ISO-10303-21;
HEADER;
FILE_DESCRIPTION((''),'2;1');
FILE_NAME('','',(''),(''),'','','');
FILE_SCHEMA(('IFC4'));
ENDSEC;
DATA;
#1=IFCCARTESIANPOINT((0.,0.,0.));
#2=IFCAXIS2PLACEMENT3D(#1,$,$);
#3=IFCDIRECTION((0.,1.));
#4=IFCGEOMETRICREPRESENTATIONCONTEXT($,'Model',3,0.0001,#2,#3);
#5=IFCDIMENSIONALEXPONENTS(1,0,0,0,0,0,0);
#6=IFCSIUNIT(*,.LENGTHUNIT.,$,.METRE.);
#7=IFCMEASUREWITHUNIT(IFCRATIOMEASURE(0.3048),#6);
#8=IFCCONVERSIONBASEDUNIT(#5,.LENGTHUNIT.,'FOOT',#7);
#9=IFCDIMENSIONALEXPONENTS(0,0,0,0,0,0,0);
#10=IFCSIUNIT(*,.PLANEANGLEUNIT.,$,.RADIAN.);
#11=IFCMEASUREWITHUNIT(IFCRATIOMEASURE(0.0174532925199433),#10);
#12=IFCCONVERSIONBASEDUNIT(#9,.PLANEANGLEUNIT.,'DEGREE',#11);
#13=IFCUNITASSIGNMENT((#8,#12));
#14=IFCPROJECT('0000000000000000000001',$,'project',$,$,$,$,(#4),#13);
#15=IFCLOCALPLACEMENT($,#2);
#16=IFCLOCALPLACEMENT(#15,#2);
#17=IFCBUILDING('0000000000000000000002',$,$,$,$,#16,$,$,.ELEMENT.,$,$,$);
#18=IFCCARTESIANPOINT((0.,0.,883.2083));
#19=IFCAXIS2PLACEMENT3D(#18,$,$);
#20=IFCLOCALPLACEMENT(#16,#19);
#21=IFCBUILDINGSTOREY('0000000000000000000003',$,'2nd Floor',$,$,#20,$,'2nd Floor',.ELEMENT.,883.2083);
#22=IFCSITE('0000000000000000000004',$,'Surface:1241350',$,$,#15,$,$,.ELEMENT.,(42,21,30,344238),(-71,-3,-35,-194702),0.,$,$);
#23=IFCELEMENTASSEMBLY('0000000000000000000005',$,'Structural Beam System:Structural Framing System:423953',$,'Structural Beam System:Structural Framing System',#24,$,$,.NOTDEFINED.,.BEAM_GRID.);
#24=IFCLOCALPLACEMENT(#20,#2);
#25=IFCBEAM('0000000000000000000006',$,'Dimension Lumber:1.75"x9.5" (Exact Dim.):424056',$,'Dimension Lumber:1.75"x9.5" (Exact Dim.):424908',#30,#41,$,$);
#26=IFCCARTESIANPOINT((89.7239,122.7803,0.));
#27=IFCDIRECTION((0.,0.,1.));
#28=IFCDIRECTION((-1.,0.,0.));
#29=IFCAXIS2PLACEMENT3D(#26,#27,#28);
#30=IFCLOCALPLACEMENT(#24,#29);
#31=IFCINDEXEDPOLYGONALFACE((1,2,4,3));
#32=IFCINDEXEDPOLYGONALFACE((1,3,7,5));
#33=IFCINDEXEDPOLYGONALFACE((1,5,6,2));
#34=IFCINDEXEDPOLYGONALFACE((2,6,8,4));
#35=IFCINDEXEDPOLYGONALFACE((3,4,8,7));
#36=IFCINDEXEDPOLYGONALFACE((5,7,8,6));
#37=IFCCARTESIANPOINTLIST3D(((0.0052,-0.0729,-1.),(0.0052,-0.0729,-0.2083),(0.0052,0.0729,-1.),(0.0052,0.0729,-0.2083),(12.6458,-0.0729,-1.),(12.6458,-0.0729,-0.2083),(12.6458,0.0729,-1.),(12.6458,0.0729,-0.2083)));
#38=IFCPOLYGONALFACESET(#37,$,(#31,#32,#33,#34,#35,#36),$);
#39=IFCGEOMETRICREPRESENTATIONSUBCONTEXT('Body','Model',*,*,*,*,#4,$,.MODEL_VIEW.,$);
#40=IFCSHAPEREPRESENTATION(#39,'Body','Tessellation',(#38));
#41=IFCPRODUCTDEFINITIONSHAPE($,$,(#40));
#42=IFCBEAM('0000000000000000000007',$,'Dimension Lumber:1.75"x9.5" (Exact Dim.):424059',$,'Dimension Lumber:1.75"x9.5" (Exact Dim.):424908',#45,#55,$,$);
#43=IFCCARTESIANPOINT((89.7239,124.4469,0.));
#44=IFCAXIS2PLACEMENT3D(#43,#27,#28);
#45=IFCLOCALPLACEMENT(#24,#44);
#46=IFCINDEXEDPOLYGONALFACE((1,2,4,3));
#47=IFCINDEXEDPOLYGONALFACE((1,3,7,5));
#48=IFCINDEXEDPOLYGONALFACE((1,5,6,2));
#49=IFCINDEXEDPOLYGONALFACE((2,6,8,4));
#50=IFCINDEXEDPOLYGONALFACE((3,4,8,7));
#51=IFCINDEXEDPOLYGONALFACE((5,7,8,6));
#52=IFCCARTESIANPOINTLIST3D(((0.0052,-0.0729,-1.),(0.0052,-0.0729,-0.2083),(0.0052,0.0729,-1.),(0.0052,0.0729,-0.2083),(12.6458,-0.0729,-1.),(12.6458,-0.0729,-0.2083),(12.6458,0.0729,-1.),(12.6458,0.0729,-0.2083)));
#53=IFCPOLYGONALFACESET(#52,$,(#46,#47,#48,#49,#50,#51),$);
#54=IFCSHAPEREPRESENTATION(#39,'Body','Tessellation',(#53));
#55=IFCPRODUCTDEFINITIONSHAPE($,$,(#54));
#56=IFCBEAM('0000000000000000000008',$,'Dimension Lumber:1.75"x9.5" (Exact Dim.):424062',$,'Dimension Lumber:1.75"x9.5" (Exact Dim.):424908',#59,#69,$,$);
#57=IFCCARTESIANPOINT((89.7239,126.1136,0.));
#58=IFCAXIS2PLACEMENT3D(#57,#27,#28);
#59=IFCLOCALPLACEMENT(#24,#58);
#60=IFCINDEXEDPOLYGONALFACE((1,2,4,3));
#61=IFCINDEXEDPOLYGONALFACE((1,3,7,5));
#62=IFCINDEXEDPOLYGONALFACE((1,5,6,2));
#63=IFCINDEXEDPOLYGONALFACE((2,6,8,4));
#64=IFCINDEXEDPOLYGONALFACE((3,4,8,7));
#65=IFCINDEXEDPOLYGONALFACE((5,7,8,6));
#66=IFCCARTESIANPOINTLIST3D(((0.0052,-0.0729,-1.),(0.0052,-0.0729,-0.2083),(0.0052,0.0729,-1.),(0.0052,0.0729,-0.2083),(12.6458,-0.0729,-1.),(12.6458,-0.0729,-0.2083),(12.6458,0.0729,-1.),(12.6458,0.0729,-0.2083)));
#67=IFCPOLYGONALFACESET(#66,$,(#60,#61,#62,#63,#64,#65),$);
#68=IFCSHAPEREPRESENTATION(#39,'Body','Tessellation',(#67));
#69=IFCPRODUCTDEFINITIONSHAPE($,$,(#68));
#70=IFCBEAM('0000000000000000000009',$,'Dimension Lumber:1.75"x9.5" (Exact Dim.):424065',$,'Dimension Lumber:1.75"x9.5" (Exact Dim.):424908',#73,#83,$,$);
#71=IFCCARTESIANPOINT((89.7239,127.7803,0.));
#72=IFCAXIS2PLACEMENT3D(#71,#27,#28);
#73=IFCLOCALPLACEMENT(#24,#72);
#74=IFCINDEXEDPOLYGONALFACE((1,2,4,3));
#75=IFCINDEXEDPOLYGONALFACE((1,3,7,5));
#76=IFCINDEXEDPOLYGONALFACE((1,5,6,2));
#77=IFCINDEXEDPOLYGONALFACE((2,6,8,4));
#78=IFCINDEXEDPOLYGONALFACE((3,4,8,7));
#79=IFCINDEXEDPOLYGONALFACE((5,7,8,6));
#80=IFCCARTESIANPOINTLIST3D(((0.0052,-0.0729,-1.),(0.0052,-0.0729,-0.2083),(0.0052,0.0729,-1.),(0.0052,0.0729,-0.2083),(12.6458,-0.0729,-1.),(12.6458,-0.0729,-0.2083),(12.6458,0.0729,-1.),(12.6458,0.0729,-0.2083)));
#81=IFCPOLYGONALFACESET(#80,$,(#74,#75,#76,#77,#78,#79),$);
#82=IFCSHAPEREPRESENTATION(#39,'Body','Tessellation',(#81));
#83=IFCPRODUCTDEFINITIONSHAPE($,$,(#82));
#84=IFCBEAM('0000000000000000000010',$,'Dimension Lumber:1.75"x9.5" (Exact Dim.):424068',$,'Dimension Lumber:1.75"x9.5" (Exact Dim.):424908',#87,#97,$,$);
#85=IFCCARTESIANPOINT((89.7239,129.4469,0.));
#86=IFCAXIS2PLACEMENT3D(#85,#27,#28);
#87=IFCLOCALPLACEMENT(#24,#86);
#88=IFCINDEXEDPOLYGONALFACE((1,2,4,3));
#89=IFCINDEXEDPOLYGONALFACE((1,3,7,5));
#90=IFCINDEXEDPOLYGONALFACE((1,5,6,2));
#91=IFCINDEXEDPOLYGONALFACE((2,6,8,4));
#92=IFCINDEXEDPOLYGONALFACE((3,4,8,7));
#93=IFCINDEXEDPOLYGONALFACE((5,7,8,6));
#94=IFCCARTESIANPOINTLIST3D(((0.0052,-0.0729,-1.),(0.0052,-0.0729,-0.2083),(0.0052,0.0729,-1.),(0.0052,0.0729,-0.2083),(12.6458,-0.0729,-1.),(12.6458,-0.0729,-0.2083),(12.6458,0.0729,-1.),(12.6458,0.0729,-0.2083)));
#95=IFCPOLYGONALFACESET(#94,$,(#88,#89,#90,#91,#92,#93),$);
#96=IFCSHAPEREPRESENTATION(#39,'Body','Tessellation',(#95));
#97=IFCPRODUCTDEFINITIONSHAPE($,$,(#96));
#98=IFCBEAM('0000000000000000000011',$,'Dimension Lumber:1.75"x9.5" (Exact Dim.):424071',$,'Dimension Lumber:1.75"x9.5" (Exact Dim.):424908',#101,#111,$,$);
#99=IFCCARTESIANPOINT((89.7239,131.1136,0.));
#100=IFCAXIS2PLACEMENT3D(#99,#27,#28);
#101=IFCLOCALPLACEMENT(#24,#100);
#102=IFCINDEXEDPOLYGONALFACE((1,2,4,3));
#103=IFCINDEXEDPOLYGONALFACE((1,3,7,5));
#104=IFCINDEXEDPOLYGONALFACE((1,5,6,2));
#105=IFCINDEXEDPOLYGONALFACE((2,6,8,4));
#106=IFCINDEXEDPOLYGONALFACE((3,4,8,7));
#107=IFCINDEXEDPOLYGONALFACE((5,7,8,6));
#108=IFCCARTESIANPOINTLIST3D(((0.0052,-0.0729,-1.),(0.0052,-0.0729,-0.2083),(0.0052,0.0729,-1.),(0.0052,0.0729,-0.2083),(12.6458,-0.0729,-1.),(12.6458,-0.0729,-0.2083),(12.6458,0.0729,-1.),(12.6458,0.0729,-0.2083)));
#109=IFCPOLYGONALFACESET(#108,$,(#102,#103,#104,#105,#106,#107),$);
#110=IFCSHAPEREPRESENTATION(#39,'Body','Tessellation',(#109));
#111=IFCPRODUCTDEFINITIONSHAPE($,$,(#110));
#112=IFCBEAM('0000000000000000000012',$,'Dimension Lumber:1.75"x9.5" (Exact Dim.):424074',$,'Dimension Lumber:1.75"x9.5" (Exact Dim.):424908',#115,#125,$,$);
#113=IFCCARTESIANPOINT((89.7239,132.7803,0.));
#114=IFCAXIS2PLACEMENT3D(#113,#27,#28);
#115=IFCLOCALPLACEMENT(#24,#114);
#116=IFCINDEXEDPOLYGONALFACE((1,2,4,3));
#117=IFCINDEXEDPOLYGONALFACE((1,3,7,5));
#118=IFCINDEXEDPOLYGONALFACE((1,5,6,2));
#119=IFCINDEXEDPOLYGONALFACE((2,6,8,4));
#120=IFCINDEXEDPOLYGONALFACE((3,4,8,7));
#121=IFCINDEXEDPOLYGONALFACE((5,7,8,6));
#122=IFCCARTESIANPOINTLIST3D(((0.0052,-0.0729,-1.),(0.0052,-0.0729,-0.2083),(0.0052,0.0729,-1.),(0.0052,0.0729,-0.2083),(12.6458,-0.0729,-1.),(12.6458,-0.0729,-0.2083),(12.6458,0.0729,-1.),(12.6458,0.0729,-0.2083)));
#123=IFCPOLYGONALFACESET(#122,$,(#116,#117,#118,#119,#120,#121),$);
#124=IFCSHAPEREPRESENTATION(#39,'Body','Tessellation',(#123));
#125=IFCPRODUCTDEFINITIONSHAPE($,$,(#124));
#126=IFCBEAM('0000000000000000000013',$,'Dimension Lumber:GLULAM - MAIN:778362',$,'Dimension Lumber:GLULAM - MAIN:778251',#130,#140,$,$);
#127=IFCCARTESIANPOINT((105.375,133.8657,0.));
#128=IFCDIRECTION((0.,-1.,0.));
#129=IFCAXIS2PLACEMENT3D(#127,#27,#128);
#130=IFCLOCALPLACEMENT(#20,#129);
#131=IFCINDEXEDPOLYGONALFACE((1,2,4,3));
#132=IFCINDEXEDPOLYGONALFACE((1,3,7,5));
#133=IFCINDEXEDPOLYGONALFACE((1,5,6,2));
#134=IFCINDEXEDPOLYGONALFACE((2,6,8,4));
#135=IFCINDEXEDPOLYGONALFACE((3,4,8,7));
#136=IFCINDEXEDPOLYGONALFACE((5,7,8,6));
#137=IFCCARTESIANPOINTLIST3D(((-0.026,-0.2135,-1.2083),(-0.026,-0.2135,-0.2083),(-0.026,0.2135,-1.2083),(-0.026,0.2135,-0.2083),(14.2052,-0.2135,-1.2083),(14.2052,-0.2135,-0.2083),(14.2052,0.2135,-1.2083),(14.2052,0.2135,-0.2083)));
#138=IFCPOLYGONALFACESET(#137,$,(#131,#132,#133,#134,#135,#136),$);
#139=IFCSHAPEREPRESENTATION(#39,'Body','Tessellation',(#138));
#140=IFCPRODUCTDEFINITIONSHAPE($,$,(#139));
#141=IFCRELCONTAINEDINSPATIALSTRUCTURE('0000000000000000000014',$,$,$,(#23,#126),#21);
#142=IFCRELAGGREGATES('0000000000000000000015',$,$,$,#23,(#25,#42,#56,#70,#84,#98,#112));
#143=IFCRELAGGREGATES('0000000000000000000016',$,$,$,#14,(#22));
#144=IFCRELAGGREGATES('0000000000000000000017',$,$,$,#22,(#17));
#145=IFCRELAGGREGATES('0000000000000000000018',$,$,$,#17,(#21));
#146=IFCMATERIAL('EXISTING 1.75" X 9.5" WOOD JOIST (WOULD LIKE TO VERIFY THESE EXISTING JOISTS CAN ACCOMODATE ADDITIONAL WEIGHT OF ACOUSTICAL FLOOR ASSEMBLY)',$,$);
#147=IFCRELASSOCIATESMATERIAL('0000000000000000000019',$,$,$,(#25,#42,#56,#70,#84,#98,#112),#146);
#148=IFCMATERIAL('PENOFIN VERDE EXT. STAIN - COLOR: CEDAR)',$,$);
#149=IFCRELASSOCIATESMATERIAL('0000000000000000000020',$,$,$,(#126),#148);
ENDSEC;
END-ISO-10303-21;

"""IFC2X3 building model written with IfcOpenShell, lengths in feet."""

from ifc_helpers import new_model, entity, si_unit, converted_unit, direction, frame, frame_2d, origin, origin_2d_with_axis, place, context, subcontext, project, spatial, rectangle, extrude, material, element, aggregate, save


model = new_model("IFC2X3")

# Units and contexts
model_context = context("Model", 3, precision=0.0001, world=origin(), true_north=direction((0.0, 1.0)))
body_context = subcontext(model_context, "Body", "Model", "MODEL_VIEW")
ifc_project = project(units=[converted_unit("LENGTHUNIT", "FOOT", entity("IfcRatioMeasure", 0.3048), si_unit("LENGTHUNIT", "METRE"), dimensions=[1, 0, 0, 0, 0, 0, 0]), converted_unit("PLANEANGLEUNIT", "DEGREE", entity("IfcRatioMeasure", 0.0174532925199433), si_unit("PLANEANGLEUNIT", "RADIAN"), dimensions=[0, 0, 0, 0, 0, 0, 0])], contexts=[model_context])

# Site, building, storey
site_placement = place(None, origin())
site = spatial("IfcSite", under=ifc_project, at=site_placement, Name="Surface:1241350", CompositionType="ELEMENT", RefLatitude=(42, 21, 30, 344238), RefLongitude=(-71, -3, -35, -194702), RefElevation=0.0)
building_placement = place(site_placement, origin())
building = spatial("IfcBuilding", under=site, at=building_placement, CompositionType="ELEMENT")
storey_placement = place(building_placement, frame((0.0, 0.0, 883.2083)))
storey = spatial("IfcBuildingStorey", under=building, at=storey_placement, Name="2nd Floor", LongName="2nd Floor", CompositionType="ELEMENT", Elevation=883.2083)

# Element assembly, beams
assembly_placement = place(storey_placement, origin())
assembly = element("IfcElementAssembly", 1, at=assembly_placement, inside=storey, Name="Structural Beam System:Structural Framing System:423953", ObjectType="Structural Beam System:Structural Framing System", AssemblyPlace="NOTDEFINED", PredefinedType="BEAM_GRID")
ifc_material_1 = material(Name="EXISTING 1.75\" X 9.5\" WOOD JOIST (WOULD LIKE TO VERIFY THESE EXISTING JOISTS CAN ACCOMODATE ADDITIONAL WEIGHT OF ACOUSTICAL FLOOR ASSEMBLY)")
beam_1_placement = place(assembly_placement, frame((89.7239, 122.7803, 0.0), z_axis=(0.0, 0.0, 1.0), x_axis=(-1.0, 0.0, 0.0)))
beam_1 = element("IfcBeam", 2, at=beam_1_placement, material=ifc_material_1, Name="Dimension Lumber:1.75\"x9.5\" (Exact Dim.):424056", ObjectType="Dimension Lumber:1.75\"x9.5\" (Exact Dim.):424908", context=body_context, shape_type="SweptSolid", body=[
    extrude(rectangle(XDim=0.7917, YDim=0.1458, at=origin_2d_with_axis()), frame((0.0052, 0.0, -0.6042), z_axis=(1.0, 0.0, 0.0), x_axis=(0.0, 0.0, -1.0)), (0.0, 0.0, 1.0), 12.6406),
])
beam_2_placement = place(assembly_placement, frame((89.7239, 124.4469, 0.0), z_axis=(0.0, 0.0, 1.0), x_axis=(-1.0, 0.0, 0.0)))
beam_2 = element("IfcBeam", 3, at=beam_2_placement, material=ifc_material_1, Name="Dimension Lumber:1.75\"x9.5\" (Exact Dim.):424059", ObjectType="Dimension Lumber:1.75\"x9.5\" (Exact Dim.):424908", context=body_context, shape_type="SweptSolid", body=[
    extrude(rectangle(XDim=0.7917, YDim=0.1458, at=frame_2d((0.0, 0.0), x_axis=(1.0, 0.0))), frame((0.0052, 0.0, -0.6042), z_axis=(1.0, 0.0, 0.0), x_axis=(0.0, 0.0, -1.0)), (0.0, 0.0, 1.0), 12.6406),
])
beam_3_placement = place(assembly_placement, frame((89.7239, 126.1136, 0.0), z_axis=(0.0, 0.0, 1.0), x_axis=(-1.0, 0.0, 0.0)))
beam_3 = element("IfcBeam", 4, at=beam_3_placement, material=ifc_material_1, Name="Dimension Lumber:1.75\"x9.5\" (Exact Dim.):424062", ObjectType="Dimension Lumber:1.75\"x9.5\" (Exact Dim.):424908", context=body_context, shape_type="SweptSolid", body=[
    extrude(rectangle(XDim=0.7917, YDim=0.1458, at=origin_2d_with_axis()), frame((0.0052, 0.0, -0.6042), z_axis=(1.0, 0.0, 0.0), x_axis=(0.0, 0.0, -1.0)), (0.0, 0.0, 1.0), 12.6406),
])
beam_4_placement = place(assembly_placement, frame((89.7239, 127.7803, 0.0), z_axis=(0.0, 0.0, 1.0), x_axis=(-1.0, 0.0, 0.0)))
beam_4 = element("IfcBeam", 5, at=beam_4_placement, material=ifc_material_1, Name="Dimension Lumber:1.75\"x9.5\" (Exact Dim.):424065", ObjectType="Dimension Lumber:1.75\"x9.5\" (Exact Dim.):424908", context=body_context, shape_type="SweptSolid", body=[
    extrude(rectangle(XDim=0.7917, YDim=0.1458, at=origin_2d_with_axis()), frame((0.0052, 0.0, -0.6042), z_axis=(1.0, 0.0, 0.0), x_axis=(0.0, 0.0, -1.0)), (0.0, 0.0, 1.0), 12.6406),
])
beam_5_placement = place(assembly_placement, frame((89.7239, 129.4469, 0.0), z_axis=(0.0, 0.0, 1.0), x_axis=(-1.0, 0.0, 0.0)))
beam_5 = element("IfcBeam", 6, at=beam_5_placement, material=ifc_material_1, Name="Dimension Lumber:1.75\"x9.5\" (Exact Dim.):424068", ObjectType="Dimension Lumber:1.75\"x9.5\" (Exact Dim.):424908", context=body_context, shape_type="SweptSolid", body=[
    extrude(rectangle(XDim=0.7917, YDim=0.1458, at=frame_2d((0.0, 0.0), x_axis=(1.0, 0.0))), frame((0.0052, 0.0, -0.6042), z_axis=(1.0, 0.0, 0.0), x_axis=(0.0, 0.0, -1.0)), (0.0, 0.0, 1.0), 12.6406),
])
beam_6_placement = place(assembly_placement, frame((89.7239, 131.1136, 0.0), z_axis=(0.0, 0.0, 1.0), x_axis=(-1.0, 0.0, 0.0)))
beam_6 = element("IfcBeam", 7, at=beam_6_placement, material=ifc_material_1, Name="Dimension Lumber:1.75\"x9.5\" (Exact Dim.):424071", ObjectType="Dimension Lumber:1.75\"x9.5\" (Exact Dim.):424908", context=body_context, shape_type="SweptSolid", body=[
    extrude(rectangle(XDim=0.7917, YDim=0.1458, at=frame_2d((0.0, 0.0), x_axis=(1.0, 0.0))), frame((0.0052, 0.0, -0.6042), z_axis=(1.0, 0.0, 0.0), x_axis=(0.0, 0.0, -1.0)), (0.0, 0.0, 1.0), 12.6406),
])
beam_7_placement = place(assembly_placement, frame((89.7239, 132.7803, 0.0), z_axis=(0.0, 0.0, 1.0), x_axis=(-1.0, 0.0, 0.0)))
beam_7 = element("IfcBeam", 8, at=beam_7_placement, material=ifc_material_1, Name="Dimension Lumber:1.75\"x9.5\" (Exact Dim.):424074", ObjectType="Dimension Lumber:1.75\"x9.5\" (Exact Dim.):424908", context=body_context, shape_type="SweptSolid", body=[
    extrude(rectangle(XDim=0.7917, YDim=0.1458, at=frame_2d((0.0, 0.0), x_axis=(1.0, 0.0))), frame((0.0052, 0.0, -0.6042), z_axis=(1.0, 0.0, 0.0), x_axis=(0.0, 0.0, -1.0)), (0.0, 0.0, 1.0), 12.6406),
])
aggregate(assembly, [beam_1, beam_2, beam_3, beam_4, beam_5, beam_6, beam_7])

# Beam
ifc_material_2 = material(Name="PENOFIN VERDE EXT. STAIN - COLOR: CEDAR)")
beam_8_placement = place(storey_placement, frame((105.375, 133.8657, 0.0), z_axis=(0.0, 0.0, 1.0), x_axis=(0.0, -1.0, 0.0)))
element("IfcBeam", 9, at=beam_8_placement, inside=storey, material=ifc_material_2, Name="Dimension Lumber:GLULAM - MAIN:778362", ObjectType="Dimension Lumber:GLULAM - MAIN:778251", context=body_context, shape_type="SweptSolid", body=[
    extrude(rectangle(XDim=1.0, YDim=0.4271, at=frame_2d((0.0, 0.0), x_axis=(1.0, 0.0))), frame((-0.026, 0.0, -0.7083), z_axis=(1.0, 0.0, 0.0), x_axis=(0.0, 0.0, -1.0)), (0.0, 0.0, 1.0), 14.2313),
])

save(model, "model.ifc")
